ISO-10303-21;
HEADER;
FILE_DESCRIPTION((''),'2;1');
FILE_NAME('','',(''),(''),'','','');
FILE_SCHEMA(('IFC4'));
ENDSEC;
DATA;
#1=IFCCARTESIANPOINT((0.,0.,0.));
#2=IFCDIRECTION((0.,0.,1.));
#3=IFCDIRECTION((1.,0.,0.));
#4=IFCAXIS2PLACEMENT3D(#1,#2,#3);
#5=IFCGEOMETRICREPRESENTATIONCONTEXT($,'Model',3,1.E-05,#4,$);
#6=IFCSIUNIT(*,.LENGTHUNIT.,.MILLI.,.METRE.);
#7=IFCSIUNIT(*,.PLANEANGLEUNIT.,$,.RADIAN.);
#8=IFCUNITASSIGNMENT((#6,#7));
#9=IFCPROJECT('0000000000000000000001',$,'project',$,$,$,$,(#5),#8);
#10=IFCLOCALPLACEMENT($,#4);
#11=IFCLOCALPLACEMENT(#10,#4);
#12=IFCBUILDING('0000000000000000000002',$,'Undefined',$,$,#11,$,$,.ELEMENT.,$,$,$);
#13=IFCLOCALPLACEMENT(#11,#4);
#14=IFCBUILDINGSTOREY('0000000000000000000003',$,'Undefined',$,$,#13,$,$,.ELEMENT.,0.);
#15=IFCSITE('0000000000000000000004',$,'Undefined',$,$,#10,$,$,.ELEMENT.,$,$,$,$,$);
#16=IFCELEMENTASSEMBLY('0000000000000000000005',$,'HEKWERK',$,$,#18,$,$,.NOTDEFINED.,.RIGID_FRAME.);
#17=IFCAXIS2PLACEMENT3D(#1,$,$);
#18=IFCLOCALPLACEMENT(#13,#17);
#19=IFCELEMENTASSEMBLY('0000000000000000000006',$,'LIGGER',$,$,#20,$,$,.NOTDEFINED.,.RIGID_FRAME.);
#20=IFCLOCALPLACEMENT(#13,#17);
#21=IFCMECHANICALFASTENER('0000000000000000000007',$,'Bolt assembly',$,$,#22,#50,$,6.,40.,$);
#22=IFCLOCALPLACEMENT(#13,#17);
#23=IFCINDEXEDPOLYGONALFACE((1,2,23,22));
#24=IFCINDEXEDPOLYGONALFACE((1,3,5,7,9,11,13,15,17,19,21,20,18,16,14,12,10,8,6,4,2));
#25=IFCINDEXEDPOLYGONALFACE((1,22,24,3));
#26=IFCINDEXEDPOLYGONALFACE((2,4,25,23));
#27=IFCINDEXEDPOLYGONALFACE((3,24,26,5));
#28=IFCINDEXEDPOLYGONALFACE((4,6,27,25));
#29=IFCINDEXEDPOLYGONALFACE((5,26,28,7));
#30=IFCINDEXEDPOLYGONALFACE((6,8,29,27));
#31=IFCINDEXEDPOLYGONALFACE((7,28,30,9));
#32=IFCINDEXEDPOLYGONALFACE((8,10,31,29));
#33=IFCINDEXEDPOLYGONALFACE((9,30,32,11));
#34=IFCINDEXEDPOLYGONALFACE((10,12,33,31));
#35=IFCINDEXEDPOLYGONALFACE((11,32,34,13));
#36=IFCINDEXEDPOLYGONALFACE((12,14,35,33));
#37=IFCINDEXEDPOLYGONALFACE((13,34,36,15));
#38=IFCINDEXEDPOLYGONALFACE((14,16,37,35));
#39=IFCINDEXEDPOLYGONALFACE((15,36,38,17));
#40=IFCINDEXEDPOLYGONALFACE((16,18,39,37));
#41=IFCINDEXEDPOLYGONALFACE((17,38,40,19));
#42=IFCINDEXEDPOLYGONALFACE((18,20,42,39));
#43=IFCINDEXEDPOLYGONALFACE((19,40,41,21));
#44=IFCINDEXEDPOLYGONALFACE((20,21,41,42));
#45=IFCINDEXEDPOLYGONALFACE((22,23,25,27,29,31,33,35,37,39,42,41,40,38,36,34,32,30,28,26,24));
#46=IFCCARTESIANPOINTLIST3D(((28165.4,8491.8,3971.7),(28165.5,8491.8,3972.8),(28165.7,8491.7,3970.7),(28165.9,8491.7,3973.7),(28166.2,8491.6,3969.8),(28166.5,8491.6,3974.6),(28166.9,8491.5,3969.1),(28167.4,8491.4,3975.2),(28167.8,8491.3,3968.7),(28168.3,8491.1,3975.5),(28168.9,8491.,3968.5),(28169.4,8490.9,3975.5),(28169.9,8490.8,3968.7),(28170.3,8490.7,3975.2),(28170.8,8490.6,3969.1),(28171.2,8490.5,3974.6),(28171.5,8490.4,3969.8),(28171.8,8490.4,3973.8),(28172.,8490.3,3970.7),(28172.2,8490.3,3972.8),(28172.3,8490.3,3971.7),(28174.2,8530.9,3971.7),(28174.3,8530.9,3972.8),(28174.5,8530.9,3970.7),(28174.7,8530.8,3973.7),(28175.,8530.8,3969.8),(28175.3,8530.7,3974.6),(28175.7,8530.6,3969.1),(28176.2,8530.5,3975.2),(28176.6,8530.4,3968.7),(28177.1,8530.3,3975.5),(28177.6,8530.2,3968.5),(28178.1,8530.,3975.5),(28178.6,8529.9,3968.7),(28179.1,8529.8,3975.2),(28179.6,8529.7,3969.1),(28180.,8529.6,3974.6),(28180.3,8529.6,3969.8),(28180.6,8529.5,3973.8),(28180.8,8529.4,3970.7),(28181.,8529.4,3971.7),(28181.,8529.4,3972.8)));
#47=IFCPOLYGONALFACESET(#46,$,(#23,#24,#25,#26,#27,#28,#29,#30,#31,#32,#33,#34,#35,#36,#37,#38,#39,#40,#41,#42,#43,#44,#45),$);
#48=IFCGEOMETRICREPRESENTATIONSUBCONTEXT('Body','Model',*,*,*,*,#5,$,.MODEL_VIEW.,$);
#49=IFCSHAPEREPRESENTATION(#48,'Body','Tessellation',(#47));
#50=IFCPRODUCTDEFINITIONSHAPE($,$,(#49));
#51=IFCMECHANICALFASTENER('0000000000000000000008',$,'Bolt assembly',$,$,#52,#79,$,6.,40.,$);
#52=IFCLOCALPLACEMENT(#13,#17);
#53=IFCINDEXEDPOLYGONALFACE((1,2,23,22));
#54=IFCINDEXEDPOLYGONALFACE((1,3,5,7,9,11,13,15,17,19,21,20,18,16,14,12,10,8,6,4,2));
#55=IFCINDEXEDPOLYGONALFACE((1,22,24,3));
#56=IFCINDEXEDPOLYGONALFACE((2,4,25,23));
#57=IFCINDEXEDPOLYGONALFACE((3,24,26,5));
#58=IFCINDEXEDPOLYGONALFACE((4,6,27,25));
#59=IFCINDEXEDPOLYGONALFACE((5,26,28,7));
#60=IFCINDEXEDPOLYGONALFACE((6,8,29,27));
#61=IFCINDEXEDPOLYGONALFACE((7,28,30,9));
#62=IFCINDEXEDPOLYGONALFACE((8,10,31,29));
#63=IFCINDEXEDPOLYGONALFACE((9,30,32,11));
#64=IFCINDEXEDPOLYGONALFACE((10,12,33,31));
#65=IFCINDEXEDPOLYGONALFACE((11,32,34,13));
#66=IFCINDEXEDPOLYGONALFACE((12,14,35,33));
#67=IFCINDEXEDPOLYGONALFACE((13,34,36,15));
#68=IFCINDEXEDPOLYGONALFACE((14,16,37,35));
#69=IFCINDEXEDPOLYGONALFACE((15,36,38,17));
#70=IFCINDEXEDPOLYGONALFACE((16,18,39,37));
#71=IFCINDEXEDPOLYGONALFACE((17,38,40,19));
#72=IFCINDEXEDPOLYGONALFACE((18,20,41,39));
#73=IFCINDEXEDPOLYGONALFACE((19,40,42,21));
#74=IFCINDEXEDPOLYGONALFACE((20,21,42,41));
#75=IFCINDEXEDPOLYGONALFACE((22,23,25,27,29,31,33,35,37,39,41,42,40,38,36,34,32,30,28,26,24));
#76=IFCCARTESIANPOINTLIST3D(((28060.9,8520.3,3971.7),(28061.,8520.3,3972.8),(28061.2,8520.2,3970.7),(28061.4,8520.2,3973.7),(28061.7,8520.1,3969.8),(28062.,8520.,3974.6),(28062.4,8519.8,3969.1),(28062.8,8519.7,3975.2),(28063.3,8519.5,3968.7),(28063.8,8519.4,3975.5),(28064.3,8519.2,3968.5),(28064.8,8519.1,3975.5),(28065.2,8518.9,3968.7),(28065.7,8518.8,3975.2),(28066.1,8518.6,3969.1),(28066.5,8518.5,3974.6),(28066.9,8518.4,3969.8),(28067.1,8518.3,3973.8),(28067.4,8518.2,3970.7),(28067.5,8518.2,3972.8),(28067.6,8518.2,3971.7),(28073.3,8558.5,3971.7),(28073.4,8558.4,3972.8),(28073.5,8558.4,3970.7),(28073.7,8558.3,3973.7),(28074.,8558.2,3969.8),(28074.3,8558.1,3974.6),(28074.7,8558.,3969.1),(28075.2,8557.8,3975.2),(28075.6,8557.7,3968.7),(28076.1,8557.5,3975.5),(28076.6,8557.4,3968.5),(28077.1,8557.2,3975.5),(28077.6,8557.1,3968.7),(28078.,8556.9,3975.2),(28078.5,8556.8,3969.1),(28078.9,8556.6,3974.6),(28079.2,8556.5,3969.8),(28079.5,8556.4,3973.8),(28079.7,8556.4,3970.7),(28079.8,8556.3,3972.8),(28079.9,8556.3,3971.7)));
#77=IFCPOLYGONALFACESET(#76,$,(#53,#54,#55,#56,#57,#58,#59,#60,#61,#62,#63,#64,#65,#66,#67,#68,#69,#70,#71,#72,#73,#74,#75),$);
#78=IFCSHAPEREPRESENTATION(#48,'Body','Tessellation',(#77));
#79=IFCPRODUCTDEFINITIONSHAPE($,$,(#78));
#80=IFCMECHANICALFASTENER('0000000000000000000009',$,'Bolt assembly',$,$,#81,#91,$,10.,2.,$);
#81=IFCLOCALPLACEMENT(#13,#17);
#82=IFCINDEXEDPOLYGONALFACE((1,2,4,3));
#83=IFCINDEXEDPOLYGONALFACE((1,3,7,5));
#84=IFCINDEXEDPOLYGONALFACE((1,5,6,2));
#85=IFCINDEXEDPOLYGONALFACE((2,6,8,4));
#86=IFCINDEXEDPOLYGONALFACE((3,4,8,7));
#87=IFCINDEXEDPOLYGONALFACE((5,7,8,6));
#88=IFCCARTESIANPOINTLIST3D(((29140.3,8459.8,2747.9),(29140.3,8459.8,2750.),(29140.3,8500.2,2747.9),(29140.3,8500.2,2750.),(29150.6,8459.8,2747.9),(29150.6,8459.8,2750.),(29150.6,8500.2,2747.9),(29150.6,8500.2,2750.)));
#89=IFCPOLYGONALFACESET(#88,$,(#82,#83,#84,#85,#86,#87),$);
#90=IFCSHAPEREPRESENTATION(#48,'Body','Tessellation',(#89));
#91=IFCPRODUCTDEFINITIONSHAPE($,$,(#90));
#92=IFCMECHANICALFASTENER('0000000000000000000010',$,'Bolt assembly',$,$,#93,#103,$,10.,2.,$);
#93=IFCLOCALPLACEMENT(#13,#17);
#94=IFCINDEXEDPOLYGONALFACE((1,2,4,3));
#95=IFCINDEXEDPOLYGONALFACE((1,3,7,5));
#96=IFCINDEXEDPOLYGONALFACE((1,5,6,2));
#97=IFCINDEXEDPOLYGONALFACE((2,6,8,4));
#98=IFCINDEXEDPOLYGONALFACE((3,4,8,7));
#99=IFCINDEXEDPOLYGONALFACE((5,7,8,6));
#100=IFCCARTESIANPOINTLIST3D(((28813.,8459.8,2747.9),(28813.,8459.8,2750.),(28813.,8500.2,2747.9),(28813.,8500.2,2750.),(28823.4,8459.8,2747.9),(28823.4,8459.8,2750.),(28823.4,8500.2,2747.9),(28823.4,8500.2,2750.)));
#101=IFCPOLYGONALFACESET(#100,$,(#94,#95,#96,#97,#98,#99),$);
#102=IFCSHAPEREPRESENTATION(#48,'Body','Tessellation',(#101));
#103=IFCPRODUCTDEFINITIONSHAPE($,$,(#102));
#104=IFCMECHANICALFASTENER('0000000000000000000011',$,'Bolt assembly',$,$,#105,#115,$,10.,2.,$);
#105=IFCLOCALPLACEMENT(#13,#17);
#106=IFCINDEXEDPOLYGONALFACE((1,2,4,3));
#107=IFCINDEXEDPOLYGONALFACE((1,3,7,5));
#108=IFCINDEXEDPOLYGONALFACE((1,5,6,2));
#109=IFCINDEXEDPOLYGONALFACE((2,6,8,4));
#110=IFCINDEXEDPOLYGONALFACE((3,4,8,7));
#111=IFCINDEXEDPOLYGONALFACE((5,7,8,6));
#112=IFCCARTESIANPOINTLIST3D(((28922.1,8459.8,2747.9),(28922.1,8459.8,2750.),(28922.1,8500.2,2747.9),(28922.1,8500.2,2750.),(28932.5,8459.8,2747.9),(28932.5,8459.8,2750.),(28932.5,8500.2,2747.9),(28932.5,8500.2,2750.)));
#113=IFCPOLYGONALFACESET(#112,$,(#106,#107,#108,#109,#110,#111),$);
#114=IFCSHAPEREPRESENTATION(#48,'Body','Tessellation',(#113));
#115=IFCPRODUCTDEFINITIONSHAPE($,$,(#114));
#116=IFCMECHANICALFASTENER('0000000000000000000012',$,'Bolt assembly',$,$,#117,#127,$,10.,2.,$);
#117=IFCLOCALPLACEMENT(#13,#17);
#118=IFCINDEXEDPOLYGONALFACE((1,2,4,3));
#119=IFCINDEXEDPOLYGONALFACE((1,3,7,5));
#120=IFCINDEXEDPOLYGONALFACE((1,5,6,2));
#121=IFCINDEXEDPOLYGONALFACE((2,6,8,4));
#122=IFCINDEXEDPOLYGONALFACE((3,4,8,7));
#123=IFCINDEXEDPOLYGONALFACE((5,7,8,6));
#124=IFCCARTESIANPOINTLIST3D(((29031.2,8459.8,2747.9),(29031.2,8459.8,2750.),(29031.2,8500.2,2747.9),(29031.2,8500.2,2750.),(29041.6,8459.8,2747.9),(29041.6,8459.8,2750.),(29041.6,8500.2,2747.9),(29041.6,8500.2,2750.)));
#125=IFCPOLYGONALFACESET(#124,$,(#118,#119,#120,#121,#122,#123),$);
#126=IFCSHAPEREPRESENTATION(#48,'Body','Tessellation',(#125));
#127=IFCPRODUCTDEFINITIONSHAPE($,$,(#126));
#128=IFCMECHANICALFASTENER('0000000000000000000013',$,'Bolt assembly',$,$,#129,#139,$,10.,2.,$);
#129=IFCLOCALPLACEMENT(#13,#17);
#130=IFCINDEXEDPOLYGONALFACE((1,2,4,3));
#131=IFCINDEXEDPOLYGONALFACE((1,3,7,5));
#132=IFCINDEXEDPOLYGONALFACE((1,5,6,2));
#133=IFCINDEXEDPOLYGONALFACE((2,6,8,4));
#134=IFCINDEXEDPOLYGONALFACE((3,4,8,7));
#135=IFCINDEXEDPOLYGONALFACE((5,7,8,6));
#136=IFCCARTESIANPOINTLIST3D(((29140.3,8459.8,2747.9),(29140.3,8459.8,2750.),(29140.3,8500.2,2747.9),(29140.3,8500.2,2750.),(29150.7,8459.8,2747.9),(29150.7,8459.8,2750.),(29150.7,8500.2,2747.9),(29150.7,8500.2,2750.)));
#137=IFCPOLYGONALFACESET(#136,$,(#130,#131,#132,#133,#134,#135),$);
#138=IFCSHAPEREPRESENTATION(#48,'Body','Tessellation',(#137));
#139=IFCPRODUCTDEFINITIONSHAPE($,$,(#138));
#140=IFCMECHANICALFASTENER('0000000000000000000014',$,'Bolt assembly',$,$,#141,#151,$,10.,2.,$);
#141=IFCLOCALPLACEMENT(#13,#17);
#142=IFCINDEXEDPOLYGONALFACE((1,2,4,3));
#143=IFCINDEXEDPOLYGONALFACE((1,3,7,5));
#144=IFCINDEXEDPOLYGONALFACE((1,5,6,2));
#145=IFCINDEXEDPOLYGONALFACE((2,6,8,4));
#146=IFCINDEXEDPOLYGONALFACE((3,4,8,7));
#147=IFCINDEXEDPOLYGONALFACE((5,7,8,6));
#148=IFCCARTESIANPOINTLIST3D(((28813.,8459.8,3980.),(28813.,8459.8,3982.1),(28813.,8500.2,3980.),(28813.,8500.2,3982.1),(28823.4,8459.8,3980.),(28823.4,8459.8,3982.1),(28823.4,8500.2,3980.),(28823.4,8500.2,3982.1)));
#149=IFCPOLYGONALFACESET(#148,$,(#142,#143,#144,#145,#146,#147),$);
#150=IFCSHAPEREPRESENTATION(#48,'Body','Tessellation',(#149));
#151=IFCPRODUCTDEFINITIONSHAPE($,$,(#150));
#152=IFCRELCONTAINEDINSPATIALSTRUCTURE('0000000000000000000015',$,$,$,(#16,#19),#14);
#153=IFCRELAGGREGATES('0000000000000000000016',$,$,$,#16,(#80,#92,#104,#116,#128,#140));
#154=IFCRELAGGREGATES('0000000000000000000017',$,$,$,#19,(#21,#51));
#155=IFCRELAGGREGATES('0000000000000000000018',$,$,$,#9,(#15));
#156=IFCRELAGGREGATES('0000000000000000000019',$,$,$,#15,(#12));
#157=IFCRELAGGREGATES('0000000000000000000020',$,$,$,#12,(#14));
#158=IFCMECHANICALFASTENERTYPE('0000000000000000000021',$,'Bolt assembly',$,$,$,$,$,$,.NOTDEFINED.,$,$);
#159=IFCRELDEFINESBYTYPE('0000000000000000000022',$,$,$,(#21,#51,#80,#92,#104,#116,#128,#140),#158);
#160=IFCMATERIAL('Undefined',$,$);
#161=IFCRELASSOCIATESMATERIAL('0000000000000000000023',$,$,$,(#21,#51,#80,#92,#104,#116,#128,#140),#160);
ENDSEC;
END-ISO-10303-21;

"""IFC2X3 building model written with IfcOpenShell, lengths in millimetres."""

from ifc_helpers import new_model, si_unit, frame, origin_with_axes, origin_2d_with_axis, place, context, subcontext, project, spatial, polyline, segment, composite_curve, circle, outline, extrude, source, transform, mapped, material, type_object, element, aggregate, save


model = new_model("IFC2X3")

# Units and contexts
model_context = context("Model", 3, precision=1e-05, world=origin_with_axes())
body_context = subcontext(model_context, "Body", "Model", "MODEL_VIEW")
ifc_project = project(units=[si_unit("LENGTHUNIT", "METRE", prefix="MILLI"), si_unit("PLANEANGLEUNIT", "RADIAN")], contexts=[model_context])

# Site, building, storey
site_placement = place(None, origin_with_axes())
site = spatial("IfcSite", under=ifc_project, at=site_placement, Name="Undefined", CompositionType="ELEMENT")
building_placement = place(site_placement, origin_with_axes())
building = spatial("IfcBuilding", under=site, at=building_placement, Name="Undefined", CompositionType="ELEMENT")
storey_placement = place(building_placement, origin_with_axes())
storey = spatial("IfcBuildingStorey", under=building, at=storey_placement, Name="Undefined", CompositionType="ELEMENT", Elevation=0.0)

# Element assemblies
assembly_1_placement = place(storey_placement, origin_with_axes())
assembly_1 = element("IfcElementAssembly", 1, at=assembly_1_placement, inside=storey, Name="HEKWERK", AssemblyPlace="NOTDEFINED", PredefinedType="RIGID_FRAME")
assembly_2_placement = place(storey_placement, origin_with_axes())
assembly_2 = element("IfcElementAssembly", 2, at=assembly_2_placement, inside=storey, Name="LIGGER", AssemblyPlace="NOTDEFINED", PredefinedType="RIGID_FRAME")

# Mechanical fasteners
ifc_material_1 = material(Name="Undefined")
mechanical_fastener_type = type_object("IfcMechanicalFastenerType", Name="Bolt assembly")
shared_shape_1 = source(origin_with_axes(), body_context, "Body", "SweptSolid", [
    extrude(circle(Radius=3.5, at=origin_2d_with_axis()), frame((0.0, -40.0, 0.0), z_axis=(0.0, 1.0, 0.0), x_axis=(1.0, 0.0, 0.0)), (0.0, 0.0, 1.0), 40.1),
])
mechanical_fastener_1_placement = place(assembly_2_placement, frame((28168.9, 8491.1, 3972.0), z_axis=(-0.975682, 0.21919, 0.0), x_axis=(0.0, 0.0, -1.0)))
mechanical_fastener_1 = element("IfcMechanicalFastener", 3, at=mechanical_fastener_1_placement, type_object=mechanical_fastener_type, material=ifc_material_1, Name="Bolt assembly", NominalDiameter=6.0, NominalLength=40.0, context=body_context, shape_type="MappedRepresentation", body=[
    mapped(shared_shape_1, transform((0.0, 0.0, 0.0))),
])
shared_shape_2 = source(origin_with_axes(), body_context, "Body", "SweptSolid", [
    extrude(circle(Radius=3.5, at=origin_2d_with_axis()), frame((0.0, -40.0, 0.0), z_axis=(0.0, 1.0, 0.0), x_axis=(1.0, 0.0, 0.0)), (0.0, 0.0, 1.0), 40.1),
])
mechanical_fastener_2_placement = place(assembly_2_placement, frame((28064.3, 8519.3, 3972.0), z_axis=(-0.951464, 0.307761, 0.0), x_axis=(0.0, 0.0, -1.0)))
mechanical_fastener_2 = element("IfcMechanicalFastener", 4, at=mechanical_fastener_2_placement, type_object=mechanical_fastener_type, material=ifc_material_1, Name="Bolt assembly", NominalDiameter=6.0, NominalLength=40.0, context=body_context, shape_type="MappedRepresentation", body=[
    mapped(shared_shape_2, transform((0.0, 0.0, 0.0))),
])
shared_shape_3 = source(origin_with_axes(), body_context, "Body", "SweptSolid", [
    extrude(outline(composite_curve([segment(polyline([(-20.2, 5.2), (20.2, 5.2)]), True, "CONTINUOUS"), segment(polyline([(20.2, 5.2), (20.2, -5.2)]), True, "CONTINUOUS"), segment(polyline([(20.2, -5.2), (-20.2, -5.2)]), True, "CONTINUOUS"), segment(polyline([(-20.2, -5.2), (-20.2, 5.2)]), True, "CONTINUOUS")], self_intersect=False)), frame((0.0, -1.0, 0.0), z_axis=(0.0, 1.0, 0.0), x_axis=(1.0, 0.0, 0.0)), (0.0, 0.0, 1.0), 2.1),
])
mechanical_fastener_3_placement = place(assembly_1_placement, frame((29145.4, 8480.0, 2749.0), z_axis=(1.0, 0.0, 0.0), x_axis=(0.0, -1.0, 0.0)))
mechanical_fastener_3 = element("IfcMechanicalFastener", 5, at=mechanical_fastener_3_placement, type_object=mechanical_fastener_type, material=ifc_material_1, Name="Bolt assembly", NominalDiameter=10.0, NominalLength=2.0, context=body_context, shape_type="MappedRepresentation", body=[
    mapped(shared_shape_3, transform((0.0, 0.0, 0.0))),
])
shared_shape_4 = source(origin_with_axes(), body_context, "Body", "SweptSolid", [
    extrude(outline(composite_curve([segment(polyline([(-20.2, 5.2), (20.2, 5.2)]), True, "CONTINUOUS"), segment(polyline([(20.2, 5.2), (20.2, -5.2)]), True, "CONTINUOUS"), segment(polyline([(20.2, -5.2), (-20.2, -5.2)]), True, "CONTINUOUS"), segment(polyline([(-20.2, -5.2), (-20.2, 5.2)]), True, "CONTINUOUS")], self_intersect=False)), frame((0.0, -1.0, 0.0), z_axis=(0.0, 1.0, 0.0), x_axis=(1.0, 0.0, 0.0)), (0.0, 0.0, 1.0), 2.1),
])
mechanical_fastener_4_placement = place(assembly_1_placement, frame((28818.2, 8480.0, 2749.0), z_axis=(1.0, 0.0, 0.0), x_axis=(0.0, -1.0, 0.0)))
mechanical_fastener_4 = element("IfcMechanicalFastener", 6, at=mechanical_fastener_4_placement, type_object=mechanical_fastener_type, material=ifc_material_1, Name="Bolt assembly", NominalDiameter=10.0, NominalLength=2.0, context=body_context, shape_type="MappedRepresentation", body=[
    mapped(shared_shape_4, transform((0.0, 0.0, 0.0))),
])
shared_shape_5 = source(origin_with_axes(), body_context, "Body", "SweptSolid", [
    extrude(outline(composite_curve([segment(polyline([(-20.2, 5.2), (20.2, 5.2)]), True, "CONTINUOUS"), segment(polyline([(20.2, 5.2), (20.2, -5.2)]), True, "CONTINUOUS"), segment(polyline([(20.2, -5.2), (-20.2, -5.2)]), True, "CONTINUOUS"), segment(polyline([(-20.2, -5.2), (-20.2, 5.2)]), True, "CONTINUOUS")], self_intersect=False)), frame((0.0, -1.0, 0.0), z_axis=(0.0, 1.0, 0.0), x_axis=(1.0, 0.0, 0.0)), (0.0, 0.0, 1.0), 2.1),
])
mechanical_fastener_5_placement = place(assembly_1_placement, frame((28927.3, 8480.0, 2749.0), z_axis=(1.0, 0.0, 0.0), x_axis=(0.0, -1.0, 0.0)))
mechanical_fastener_5 = element("IfcMechanicalFastener", 7, at=mechanical_fastener_5_placement, type_object=mechanical_fastener_type, material=ifc_material_1, Name="Bolt assembly", NominalDiameter=10.0, NominalLength=2.0, context=body_context, shape_type="MappedRepresentation", body=[
    mapped(shared_shape_5, transform((0.0, 0.0, 0.0))),
])
shared_shape_6 = source(origin_with_axes(), body_context, "Body", "SweptSolid", [
    extrude(outline(composite_curve([segment(polyline([(-20.2, 5.2), (20.2, 5.2)]), True, "CONTINUOUS"), segment(polyline([(20.2, 5.2), (20.2, -5.2)]), True, "CONTINUOUS"), segment(polyline([(20.2, -5.2), (-20.2, -5.2)]), True, "CONTINUOUS"), segment(polyline([(-20.2, -5.2), (-20.2, 5.2)]), True, "CONTINUOUS")], self_intersect=False)), frame((0.0, -1.0, 0.0), z_axis=(0.0, 1.0, 0.0), x_axis=(1.0, 0.0, 0.0)), (0.0, 0.0, 1.0), 2.1),
])
mechanical_fastener_6_placement = place(assembly_1_placement, frame((29036.4, 8480.0, 2749.0), z_axis=(1.0, 0.0, 0.0), x_axis=(0.0, -1.0, 0.0)))
mechanical_fastener_6 = element("IfcMechanicalFastener", 8, at=mechanical_fastener_6_placement, type_object=mechanical_fastener_type, material=ifc_material_1, Name="Bolt assembly", NominalDiameter=10.0, NominalLength=2.0, context=body_context, shape_type="MappedRepresentation", body=[
    mapped(shared_shape_6, transform((0.0, 0.0, 0.0))),
])
shared_shape_7 = source(origin_with_axes(), body_context, "Body", "SweptSolid", [
    extrude(outline(composite_curve([segment(polyline([(-20.2, 5.2), (20.2, 5.2)]), True, "CONTINUOUS"), segment(polyline([(20.2, 5.2), (20.2, -5.2)]), True, "CONTINUOUS"), segment(polyline([(20.2, -5.2), (-20.2, -5.2)]), True, "CONTINUOUS"), segment(polyline([(-20.2, -5.2), (-20.2, 5.2)]), True, "CONTINUOUS")], self_intersect=False)), frame((0.0, -1.0, 0.0), z_axis=(0.0, 1.0, 0.0), x_axis=(1.0, 0.0, 0.0)), (0.0, 0.0, 1.0), 2.1),
])
mechanical_fastener_7_placement = place(assembly_1_placement, frame((29145.5, 8480.0, 2749.0), z_axis=(1.0, 0.0, 0.0), x_axis=(0.0, -1.0, 0.0)))
mechanical_fastener_7 = element("IfcMechanicalFastener", 9, at=mechanical_fastener_7_placement, type_object=mechanical_fastener_type, material=ifc_material_1, Name="Bolt assembly", NominalDiameter=10.0, NominalLength=2.0, context=body_context, shape_type="MappedRepresentation", body=[
    mapped(shared_shape_7, transform((0.0, 0.0, 0.0))),
])
shared_shape_8 = source(origin_with_axes(), body_context, "Body", "SweptSolid", [
    extrude(outline(composite_curve([segment(polyline([(-20.2, 5.2), (20.2, 5.2)]), True, "CONTINUOUS"), segment(polyline([(20.2, 5.2), (20.2, -5.2)]), True, "CONTINUOUS"), segment(polyline([(20.2, -5.2), (-20.2, -5.2)]), True, "CONTINUOUS"), segment(polyline([(-20.2, -5.2), (-20.2, 5.2)]), True, "CONTINUOUS")], self_intersect=False)), frame((0.0, -1.0, 0.0), z_axis=(0.0, 1.0, 0.0), x_axis=(1.0, 0.0, 0.0)), (0.0, 0.0, 1.0), 2.1),
])
mechanical_fastener_8_placement = place(assembly_1_placement, frame((28818.2, 8480.0, 3981.0), z_axis=(-1.0, 0.0, 0.0), x_axis=(0.0, -1.0, 0.0)))
mechanical_fastener_8 = element("IfcMechanicalFastener", 10, at=mechanical_fastener_8_placement, type_object=mechanical_fastener_type, material=ifc_material_1, Name="Bolt assembly", NominalDiameter=10.0, NominalLength=2.0, context=body_context, shape_type="MappedRepresentation", body=[
    mapped(shared_shape_8, transform((0.0, 0.0, 0.0))),
])
aggregate(assembly_1, [mechanical_fastener_3, mechanical_fastener_4, mechanical_fastener_5, mechanical_fastener_6, mechanical_fastener_7, mechanical_fastener_8])
aggregate(assembly_2, [mechanical_fastener_1, mechanical_fastener_2])

save(model, "model.ifc")
